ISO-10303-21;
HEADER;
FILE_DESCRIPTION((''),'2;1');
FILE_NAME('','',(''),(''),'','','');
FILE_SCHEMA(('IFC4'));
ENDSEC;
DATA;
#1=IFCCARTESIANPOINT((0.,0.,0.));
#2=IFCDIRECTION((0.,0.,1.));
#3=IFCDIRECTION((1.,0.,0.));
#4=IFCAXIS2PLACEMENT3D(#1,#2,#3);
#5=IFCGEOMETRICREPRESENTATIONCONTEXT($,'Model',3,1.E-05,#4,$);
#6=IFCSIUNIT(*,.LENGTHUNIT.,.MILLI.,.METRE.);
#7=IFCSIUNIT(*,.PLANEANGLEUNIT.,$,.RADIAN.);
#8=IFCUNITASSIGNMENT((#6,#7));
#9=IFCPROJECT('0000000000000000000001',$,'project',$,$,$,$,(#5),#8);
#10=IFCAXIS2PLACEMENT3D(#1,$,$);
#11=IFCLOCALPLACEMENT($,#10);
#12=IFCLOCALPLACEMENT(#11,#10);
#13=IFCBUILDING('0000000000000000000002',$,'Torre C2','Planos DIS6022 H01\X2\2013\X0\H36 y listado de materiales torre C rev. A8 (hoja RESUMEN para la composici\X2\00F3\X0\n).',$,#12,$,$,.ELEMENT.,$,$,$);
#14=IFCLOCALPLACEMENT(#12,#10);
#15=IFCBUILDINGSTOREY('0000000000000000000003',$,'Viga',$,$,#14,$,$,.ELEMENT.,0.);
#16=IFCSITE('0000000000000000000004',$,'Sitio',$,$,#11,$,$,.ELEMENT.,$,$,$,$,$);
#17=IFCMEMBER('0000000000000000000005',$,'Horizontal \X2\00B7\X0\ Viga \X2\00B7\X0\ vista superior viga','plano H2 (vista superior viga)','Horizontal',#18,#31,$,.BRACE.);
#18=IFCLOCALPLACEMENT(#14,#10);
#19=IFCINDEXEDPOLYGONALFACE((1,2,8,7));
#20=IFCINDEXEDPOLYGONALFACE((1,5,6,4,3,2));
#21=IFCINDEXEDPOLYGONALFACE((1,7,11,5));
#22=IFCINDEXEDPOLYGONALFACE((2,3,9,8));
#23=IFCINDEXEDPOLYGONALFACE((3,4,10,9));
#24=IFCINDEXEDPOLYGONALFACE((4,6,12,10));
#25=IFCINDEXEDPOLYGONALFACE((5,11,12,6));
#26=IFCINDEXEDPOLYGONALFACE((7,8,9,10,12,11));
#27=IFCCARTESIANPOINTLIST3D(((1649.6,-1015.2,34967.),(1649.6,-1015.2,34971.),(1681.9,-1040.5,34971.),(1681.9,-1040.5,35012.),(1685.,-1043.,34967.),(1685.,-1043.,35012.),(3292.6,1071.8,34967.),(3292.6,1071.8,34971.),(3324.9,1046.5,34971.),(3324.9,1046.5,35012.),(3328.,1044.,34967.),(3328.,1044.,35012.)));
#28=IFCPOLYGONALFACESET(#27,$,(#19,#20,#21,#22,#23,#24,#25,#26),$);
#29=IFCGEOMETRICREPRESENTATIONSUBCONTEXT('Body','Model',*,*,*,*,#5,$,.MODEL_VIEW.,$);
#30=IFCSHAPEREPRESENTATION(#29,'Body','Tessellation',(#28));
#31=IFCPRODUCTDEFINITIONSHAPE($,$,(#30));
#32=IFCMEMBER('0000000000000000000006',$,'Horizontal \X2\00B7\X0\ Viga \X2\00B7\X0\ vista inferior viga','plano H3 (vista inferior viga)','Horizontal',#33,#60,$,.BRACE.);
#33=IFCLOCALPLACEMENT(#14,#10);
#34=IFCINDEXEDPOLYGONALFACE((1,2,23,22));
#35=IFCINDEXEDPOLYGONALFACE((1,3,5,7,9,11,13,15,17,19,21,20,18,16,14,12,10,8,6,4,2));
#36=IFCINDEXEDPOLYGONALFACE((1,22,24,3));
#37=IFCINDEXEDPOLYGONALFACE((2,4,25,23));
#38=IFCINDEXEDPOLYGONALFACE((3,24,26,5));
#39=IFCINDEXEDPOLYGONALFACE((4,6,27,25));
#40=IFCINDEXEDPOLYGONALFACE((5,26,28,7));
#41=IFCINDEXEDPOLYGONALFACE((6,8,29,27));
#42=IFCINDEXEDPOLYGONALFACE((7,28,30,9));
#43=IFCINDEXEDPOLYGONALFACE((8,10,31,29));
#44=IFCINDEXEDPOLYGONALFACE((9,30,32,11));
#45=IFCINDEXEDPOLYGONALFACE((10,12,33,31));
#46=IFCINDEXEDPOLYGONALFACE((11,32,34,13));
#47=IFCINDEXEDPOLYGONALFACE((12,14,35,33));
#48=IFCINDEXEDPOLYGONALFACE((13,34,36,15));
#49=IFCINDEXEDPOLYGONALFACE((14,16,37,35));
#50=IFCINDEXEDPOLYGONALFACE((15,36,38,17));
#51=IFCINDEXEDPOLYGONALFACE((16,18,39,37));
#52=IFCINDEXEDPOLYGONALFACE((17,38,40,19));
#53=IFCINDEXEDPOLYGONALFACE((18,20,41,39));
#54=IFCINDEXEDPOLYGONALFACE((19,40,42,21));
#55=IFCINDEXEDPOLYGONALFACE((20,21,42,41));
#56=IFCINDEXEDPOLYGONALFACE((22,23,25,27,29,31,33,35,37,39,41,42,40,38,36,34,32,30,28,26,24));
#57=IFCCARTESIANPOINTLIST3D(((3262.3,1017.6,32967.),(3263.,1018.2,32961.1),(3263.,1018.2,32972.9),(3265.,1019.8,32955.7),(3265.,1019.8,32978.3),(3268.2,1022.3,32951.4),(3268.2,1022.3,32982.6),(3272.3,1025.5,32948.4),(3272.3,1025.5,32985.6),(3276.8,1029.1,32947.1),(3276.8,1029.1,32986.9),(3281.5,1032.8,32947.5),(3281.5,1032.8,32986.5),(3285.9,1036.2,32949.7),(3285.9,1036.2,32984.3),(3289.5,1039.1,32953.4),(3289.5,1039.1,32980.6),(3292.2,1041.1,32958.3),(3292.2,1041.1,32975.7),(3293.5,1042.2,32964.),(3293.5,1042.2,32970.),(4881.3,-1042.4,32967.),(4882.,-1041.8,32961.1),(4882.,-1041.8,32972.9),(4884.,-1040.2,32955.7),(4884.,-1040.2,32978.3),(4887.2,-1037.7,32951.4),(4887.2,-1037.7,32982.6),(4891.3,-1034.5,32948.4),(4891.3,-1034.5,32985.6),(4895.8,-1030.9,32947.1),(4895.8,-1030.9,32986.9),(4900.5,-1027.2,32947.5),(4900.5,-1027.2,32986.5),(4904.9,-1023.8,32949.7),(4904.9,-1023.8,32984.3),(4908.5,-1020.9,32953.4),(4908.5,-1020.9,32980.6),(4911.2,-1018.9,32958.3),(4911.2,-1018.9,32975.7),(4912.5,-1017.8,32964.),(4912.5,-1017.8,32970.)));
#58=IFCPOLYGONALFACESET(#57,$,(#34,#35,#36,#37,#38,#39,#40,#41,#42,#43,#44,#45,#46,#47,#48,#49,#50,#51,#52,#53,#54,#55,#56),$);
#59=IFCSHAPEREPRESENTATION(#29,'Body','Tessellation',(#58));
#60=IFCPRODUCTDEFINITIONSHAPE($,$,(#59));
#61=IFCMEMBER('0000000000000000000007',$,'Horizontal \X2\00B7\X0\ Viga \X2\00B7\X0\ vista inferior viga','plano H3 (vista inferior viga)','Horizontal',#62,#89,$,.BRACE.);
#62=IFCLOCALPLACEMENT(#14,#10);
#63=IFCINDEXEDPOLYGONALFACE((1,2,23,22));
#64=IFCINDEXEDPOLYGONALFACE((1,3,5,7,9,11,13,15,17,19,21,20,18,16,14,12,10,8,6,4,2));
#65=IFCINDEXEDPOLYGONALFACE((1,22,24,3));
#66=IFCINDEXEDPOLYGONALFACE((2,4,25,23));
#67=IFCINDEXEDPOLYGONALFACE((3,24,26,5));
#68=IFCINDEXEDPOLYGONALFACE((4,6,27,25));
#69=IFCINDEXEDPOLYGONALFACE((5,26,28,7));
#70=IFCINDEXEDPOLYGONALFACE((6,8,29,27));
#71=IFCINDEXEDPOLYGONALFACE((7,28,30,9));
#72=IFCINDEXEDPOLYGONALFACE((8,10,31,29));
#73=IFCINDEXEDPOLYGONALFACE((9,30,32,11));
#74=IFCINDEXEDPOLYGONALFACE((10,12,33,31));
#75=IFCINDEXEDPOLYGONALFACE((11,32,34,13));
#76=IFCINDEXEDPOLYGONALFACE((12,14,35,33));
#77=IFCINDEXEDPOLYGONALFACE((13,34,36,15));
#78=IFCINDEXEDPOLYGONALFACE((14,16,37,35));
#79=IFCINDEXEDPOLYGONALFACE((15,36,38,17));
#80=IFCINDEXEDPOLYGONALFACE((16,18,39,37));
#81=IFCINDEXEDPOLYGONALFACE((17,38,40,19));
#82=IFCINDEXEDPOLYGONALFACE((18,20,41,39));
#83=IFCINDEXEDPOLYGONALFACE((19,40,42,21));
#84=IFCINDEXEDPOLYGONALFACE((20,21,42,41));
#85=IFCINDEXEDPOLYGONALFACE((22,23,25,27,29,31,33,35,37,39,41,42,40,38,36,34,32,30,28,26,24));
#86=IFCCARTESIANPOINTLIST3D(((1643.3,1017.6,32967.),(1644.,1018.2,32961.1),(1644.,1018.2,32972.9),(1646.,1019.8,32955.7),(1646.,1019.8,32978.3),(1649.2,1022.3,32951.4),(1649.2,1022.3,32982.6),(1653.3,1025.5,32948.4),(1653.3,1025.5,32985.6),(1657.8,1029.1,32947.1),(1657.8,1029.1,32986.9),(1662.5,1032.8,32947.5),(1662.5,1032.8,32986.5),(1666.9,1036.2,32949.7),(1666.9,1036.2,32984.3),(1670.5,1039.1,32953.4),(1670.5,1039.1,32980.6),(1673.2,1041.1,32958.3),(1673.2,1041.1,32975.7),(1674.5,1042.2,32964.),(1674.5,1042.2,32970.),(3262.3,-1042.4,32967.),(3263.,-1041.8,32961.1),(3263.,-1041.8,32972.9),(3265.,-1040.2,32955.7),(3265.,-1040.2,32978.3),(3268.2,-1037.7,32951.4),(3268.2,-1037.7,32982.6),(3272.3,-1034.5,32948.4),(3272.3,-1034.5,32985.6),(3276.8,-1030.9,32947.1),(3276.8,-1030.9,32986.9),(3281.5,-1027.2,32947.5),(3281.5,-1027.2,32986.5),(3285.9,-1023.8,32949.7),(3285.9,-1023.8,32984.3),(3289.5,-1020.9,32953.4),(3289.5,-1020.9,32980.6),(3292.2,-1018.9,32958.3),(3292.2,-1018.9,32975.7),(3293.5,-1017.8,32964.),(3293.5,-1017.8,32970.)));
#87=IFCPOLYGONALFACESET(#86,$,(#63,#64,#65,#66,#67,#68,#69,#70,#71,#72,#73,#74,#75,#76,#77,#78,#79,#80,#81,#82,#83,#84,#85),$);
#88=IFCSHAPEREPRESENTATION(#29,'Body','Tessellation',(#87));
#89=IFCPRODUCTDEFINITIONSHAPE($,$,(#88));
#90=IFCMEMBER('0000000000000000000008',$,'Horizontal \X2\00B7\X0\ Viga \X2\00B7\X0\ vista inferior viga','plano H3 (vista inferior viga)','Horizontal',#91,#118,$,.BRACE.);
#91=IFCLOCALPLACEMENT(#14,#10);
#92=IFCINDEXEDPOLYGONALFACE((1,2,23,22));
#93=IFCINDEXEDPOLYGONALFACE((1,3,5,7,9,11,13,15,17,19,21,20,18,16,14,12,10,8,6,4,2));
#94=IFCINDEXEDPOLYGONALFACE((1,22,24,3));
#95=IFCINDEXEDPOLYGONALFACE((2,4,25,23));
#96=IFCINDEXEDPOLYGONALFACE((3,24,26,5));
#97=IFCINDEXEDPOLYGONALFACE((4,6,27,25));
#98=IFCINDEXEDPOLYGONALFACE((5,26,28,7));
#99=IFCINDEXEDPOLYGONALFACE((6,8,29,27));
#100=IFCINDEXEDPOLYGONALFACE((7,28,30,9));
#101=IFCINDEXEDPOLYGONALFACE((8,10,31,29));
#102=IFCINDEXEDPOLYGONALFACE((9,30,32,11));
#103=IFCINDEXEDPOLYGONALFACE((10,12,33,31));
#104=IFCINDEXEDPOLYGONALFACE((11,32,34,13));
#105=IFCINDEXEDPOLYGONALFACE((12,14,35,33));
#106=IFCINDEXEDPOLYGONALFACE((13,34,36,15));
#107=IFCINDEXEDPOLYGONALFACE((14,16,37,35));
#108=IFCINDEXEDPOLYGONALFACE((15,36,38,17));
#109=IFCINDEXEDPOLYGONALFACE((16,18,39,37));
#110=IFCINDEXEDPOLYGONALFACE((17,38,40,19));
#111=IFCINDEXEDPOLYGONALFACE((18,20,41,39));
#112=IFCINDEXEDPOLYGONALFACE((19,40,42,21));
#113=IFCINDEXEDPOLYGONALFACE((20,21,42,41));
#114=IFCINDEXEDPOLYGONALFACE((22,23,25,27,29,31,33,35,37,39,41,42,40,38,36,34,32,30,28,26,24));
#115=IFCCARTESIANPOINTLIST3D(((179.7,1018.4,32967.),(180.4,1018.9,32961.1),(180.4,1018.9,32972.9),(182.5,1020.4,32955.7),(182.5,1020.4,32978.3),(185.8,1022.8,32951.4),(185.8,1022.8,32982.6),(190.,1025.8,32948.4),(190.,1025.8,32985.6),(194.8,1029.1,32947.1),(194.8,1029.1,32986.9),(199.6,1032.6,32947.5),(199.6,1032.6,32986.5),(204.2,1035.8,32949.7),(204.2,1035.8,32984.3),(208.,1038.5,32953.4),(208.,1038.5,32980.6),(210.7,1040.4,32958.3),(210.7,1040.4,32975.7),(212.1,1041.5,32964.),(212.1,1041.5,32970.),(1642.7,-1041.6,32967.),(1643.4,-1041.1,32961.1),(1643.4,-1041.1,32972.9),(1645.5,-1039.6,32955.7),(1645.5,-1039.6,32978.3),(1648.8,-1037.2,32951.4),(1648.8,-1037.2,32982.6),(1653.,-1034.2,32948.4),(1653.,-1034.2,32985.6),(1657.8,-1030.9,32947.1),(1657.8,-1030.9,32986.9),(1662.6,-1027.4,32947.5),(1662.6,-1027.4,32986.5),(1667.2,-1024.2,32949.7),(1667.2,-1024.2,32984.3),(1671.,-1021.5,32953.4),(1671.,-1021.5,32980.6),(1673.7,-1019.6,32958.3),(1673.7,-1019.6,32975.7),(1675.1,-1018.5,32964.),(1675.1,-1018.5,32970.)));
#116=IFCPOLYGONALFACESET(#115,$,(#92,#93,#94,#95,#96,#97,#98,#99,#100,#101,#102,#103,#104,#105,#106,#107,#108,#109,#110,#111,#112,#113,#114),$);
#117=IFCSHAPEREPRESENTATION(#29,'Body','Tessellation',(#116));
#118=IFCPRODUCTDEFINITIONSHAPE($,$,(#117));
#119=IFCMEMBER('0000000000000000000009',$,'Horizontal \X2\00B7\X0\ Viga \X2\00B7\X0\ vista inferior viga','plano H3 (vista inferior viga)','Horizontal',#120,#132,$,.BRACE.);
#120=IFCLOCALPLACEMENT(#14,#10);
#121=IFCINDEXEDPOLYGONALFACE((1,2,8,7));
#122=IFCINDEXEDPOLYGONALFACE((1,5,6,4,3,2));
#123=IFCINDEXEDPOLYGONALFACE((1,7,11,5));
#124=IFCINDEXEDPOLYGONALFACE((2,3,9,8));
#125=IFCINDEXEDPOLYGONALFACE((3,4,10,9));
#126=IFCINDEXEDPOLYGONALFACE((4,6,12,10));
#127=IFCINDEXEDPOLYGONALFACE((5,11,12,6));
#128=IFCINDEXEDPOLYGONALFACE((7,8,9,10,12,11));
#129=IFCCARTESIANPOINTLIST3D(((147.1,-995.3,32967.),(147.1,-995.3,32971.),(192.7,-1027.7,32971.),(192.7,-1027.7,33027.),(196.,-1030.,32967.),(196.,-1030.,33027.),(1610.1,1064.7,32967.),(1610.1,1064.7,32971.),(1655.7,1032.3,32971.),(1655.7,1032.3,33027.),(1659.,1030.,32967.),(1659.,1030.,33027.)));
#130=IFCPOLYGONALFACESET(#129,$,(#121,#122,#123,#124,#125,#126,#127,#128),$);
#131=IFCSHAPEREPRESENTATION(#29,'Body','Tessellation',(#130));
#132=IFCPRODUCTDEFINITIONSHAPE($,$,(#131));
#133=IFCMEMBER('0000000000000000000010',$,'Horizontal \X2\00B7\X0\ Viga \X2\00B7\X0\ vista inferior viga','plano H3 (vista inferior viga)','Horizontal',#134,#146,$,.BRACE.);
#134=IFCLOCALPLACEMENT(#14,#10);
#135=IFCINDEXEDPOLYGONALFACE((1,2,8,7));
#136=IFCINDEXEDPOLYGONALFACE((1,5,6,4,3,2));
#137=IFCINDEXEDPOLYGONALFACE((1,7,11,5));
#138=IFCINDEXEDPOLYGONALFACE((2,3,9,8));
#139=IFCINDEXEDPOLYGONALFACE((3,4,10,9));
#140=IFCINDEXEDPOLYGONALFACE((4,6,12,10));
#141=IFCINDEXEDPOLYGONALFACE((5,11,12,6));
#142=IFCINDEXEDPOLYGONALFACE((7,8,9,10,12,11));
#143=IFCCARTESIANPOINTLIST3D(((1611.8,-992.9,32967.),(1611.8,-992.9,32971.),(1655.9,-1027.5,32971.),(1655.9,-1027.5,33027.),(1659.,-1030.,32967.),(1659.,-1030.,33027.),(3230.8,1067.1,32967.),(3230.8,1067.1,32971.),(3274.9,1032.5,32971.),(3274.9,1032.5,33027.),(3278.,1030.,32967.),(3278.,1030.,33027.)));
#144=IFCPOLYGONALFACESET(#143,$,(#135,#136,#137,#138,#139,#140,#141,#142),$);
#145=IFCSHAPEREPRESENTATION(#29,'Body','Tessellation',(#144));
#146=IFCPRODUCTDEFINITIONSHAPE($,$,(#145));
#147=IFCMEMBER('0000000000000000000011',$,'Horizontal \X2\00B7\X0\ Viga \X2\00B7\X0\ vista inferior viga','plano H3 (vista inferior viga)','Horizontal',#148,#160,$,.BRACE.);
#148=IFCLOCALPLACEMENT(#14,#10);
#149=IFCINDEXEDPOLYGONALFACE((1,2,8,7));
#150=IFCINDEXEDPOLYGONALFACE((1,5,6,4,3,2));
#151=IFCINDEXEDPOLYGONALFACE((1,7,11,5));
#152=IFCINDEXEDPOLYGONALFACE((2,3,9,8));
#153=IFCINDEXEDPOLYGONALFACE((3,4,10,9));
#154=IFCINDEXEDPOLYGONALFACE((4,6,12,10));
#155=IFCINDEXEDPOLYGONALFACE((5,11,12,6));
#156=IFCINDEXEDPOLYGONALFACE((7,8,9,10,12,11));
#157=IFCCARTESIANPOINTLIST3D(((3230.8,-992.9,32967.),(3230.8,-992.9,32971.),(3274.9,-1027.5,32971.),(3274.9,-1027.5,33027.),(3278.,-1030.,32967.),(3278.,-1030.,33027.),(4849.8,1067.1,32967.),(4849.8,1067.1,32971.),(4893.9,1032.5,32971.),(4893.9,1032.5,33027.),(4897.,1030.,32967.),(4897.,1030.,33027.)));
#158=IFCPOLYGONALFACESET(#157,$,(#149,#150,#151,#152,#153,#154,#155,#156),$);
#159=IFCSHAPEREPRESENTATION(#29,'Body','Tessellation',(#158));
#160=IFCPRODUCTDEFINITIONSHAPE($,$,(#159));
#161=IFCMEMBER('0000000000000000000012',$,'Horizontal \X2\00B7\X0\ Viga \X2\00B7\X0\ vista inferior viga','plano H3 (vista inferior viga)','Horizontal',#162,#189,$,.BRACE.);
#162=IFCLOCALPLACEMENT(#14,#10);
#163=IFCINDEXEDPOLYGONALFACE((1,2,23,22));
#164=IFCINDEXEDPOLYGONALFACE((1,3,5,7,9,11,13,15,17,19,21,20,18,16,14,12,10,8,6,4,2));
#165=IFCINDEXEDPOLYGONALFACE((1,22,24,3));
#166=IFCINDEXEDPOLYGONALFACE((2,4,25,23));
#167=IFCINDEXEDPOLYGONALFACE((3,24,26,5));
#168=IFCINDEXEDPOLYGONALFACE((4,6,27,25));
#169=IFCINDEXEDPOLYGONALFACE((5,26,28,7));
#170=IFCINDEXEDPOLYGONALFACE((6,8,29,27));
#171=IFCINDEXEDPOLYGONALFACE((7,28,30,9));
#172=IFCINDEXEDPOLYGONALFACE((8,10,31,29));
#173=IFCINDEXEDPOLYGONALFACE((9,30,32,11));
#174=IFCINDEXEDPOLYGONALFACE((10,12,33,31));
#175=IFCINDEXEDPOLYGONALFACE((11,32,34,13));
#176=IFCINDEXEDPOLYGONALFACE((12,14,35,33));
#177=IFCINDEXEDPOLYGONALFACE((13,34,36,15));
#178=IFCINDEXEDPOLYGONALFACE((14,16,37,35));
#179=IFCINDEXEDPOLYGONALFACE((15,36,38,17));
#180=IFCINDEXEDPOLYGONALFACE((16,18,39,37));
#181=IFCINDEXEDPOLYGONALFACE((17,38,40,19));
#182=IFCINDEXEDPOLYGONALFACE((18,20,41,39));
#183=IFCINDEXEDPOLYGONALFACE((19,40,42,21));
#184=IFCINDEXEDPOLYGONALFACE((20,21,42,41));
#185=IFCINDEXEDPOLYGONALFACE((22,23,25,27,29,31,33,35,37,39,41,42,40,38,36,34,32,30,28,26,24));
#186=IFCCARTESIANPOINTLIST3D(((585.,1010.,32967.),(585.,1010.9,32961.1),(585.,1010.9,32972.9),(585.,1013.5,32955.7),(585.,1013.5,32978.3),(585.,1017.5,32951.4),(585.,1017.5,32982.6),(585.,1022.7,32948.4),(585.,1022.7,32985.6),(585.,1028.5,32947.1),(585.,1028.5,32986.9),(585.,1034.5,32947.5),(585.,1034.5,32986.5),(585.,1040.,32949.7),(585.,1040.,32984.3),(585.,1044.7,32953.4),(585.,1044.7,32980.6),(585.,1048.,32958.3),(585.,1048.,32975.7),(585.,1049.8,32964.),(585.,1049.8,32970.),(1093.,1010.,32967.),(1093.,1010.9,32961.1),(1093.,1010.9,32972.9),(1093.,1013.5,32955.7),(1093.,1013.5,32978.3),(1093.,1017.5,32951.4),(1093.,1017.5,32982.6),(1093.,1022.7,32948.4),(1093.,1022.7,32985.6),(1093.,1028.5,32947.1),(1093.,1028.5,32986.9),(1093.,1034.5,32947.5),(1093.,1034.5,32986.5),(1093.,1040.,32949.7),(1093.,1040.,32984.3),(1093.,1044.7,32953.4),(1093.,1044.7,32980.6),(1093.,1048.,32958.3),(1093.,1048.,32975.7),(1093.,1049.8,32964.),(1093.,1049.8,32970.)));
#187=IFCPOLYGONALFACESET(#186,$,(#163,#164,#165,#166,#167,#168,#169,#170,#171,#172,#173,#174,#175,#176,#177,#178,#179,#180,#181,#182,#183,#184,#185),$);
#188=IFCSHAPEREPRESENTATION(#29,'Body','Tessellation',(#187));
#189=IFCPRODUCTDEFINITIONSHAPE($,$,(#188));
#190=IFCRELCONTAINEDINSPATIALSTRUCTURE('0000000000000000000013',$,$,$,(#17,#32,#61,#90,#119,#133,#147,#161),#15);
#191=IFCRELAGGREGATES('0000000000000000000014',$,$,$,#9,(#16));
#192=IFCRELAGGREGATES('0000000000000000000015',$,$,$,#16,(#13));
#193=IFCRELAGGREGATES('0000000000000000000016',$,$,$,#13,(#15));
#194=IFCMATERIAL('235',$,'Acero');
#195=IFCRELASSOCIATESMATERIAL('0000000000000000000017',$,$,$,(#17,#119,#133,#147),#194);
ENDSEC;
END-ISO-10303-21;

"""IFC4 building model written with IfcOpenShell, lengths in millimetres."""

from ifc_helpers import new_model, si_unit, frame, frame_2d, origin, origin_with_axes, place, context, subcontext, project, spatial, circle, l_section, extrude, material, element, save


model = new_model("IFC4")

# Units and contexts
model_context = context("Model", 3, precision=1e-05, world=origin_with_axes())
body_context = subcontext(model_context, "Body", "Model", "MODEL_VIEW")
ifc_project = project(units=[si_unit("LENGTHUNIT", "METRE", prefix="MILLI"), si_unit("PLANEANGLEUNIT", "RADIAN")], contexts=[model_context])

# Site, building, storey
site_placement = place(None, origin())
site = spatial("IfcSite", under=ifc_project, at=site_placement, Name="Sitio", CompositionType="ELEMENT")
building_placement = place(site_placement, origin())
building = spatial("IfcBuilding", under=site, at=building_placement, Name="Torre C2", Description="Planos DIS6022 H01–H36 y listado de materiales torre C rev. A8 (hoja RESUMEN para la composición).", CompositionType="ELEMENT")
storey_placement = place(building_placement, origin())
storey = spatial("IfcBuildingStorey", under=building, at=storey_placement, Name="Viga", CompositionType="ELEMENT", Elevation=0.0)

# Members
ifc_material_1 = material(Name="235", Category="Acero")
member_1_placement = place(storey_placement, frame((1685.0, -1043.0, 34967.0), z_axis=(0.618569, 0.78573, 0.0), x_axis=(-0.78573, 0.618569, 0.0)))
element("IfcMember", 1, at=member_1_placement, inside=storey, material=ifc_material_1, Name="Horizontal · Viga · vista superior viga", Description="plano H2 (vista superior viga)", ObjectType="Horizontal", PredefinedType="BRACE", context=body_context, shape_type="SweptSolid", body=[
    extrude(l_section(Depth=45.0, Width=45.0, Thickness=4.0, at=frame_2d((22.5, 22.5))), None, (0.0, 0.0, 1.0), 2656.1),
])
for number, where, z_axis, x_axis, name in (
    (2, (3278.0, 1030.0, 32967.0), (0.617923, -0.786239, 0.0), (-0.786239, -0.617923, 0.0), "Horizontal · Viga · vista inferior viga"),
    (3, (1659.0, 1030.0, 32967.0), (0.617923, -0.786239, 0.0), (-0.786239, -0.617923, 0.0), "Horizontal · Viga · vista inferior viga"),
):
    element("IfcMember", number, at=place(storey_placement, frame(where, z_axis=z_axis, x_axis=x_axis)), inside=storey, Name=name, Description="plano H3 (vista inferior viga)", ObjectType="Horizontal", PredefinedType="BRACE", context=body_context, shape_type="SweptSolid", body=[
        extrude(circle(Radius=20.0), None, (0.0, 0.0, 1.0), 2620.1),
    ])
member_2_placement = place(storey_placement, frame((196.0, 1030.0, 32967.0), z_axis=(0.579027, -0.815308, 0.0), x_axis=(-0.815308, -0.579027, 0.0)))
element("IfcMember", 4, at=member_2_placement, inside=storey, Name="Horizontal · Viga · vista inferior viga", Description="plano H3 (vista inferior viga)", ObjectType="Horizontal", PredefinedType="BRACE", context=body_context, shape_type="SweptSolid", body=[
    extrude(circle(Radius=20.0), None, (0.0, 0.0, 1.0), 2526.7),
])
member_3_placement = place(storey_placement, frame((196.0, -1030.0, 32967.0), z_axis=(0.579027, 0.815308, 0.0), x_axis=(-0.815308, 0.579027, 0.0)))
element("IfcMember", 5, at=member_3_placement, inside=storey, material=ifc_material_1, Name="Horizontal · Viga · vista inferior viga", Description="plano H3 (vista inferior viga)", ObjectType="Horizontal", PredefinedType="BRACE", context=body_context, shape_type="SweptSolid", body=[
    extrude(l_section(Depth=60.0, Width=60.0, Thickness=4.0, at=frame_2d((30.0, 30.0))), None, (0.0, 0.0, 1.0), 2526.7),
])
for number, where, z_axis, x_axis, name in (
    (6, (1659.0, -1030.0, 32967.0), (0.617923, 0.786239, 0.0), (-0.786239, 0.617923, 0.0), "Horizontal · Viga · vista inferior viga"),
    (7, (3278.0, -1030.0, 32967.0), (0.617923, 0.786239, 0.0), (-0.786239, 0.617923, 0.0), "Horizontal · Viga · vista inferior viga"),
):
    element("IfcMember", number, at=place(storey_placement, frame(where, z_axis=z_axis, x_axis=x_axis)), inside=storey, material=ifc_material_1, Name=name, Description="plano H3 (vista inferior viga)", ObjectType="Horizontal", PredefinedType="BRACE", context=body_context, shape_type="SweptSolid", body=[
        extrude(l_section(Depth=60.0, Width=60.0, Thickness=4.0, at=frame_2d((30.0, 30.0))), None, (0.0, 0.0, 1.0), 2620.1),
    ])
member_4_placement = place(storey_placement, frame((1093.0, 1030.0, 32967.0), z_axis=(-1.0, 0.0, 0.0), x_axis=(0.0, -1.0, 0.0)))
element("IfcMember", 8, at=member_4_placement, inside=storey, Name="Horizontal · Viga · vista inferior viga", Description="plano H3 (vista inferior viga)", ObjectType="Horizontal", PredefinedType="BRACE", context=body_context, shape_type="SweptSolid", body=[
    extrude(circle(Radius=20.0), None, (0.0, 0.0, 1.0), 508.0),
])

save(model, "model.ifc")
